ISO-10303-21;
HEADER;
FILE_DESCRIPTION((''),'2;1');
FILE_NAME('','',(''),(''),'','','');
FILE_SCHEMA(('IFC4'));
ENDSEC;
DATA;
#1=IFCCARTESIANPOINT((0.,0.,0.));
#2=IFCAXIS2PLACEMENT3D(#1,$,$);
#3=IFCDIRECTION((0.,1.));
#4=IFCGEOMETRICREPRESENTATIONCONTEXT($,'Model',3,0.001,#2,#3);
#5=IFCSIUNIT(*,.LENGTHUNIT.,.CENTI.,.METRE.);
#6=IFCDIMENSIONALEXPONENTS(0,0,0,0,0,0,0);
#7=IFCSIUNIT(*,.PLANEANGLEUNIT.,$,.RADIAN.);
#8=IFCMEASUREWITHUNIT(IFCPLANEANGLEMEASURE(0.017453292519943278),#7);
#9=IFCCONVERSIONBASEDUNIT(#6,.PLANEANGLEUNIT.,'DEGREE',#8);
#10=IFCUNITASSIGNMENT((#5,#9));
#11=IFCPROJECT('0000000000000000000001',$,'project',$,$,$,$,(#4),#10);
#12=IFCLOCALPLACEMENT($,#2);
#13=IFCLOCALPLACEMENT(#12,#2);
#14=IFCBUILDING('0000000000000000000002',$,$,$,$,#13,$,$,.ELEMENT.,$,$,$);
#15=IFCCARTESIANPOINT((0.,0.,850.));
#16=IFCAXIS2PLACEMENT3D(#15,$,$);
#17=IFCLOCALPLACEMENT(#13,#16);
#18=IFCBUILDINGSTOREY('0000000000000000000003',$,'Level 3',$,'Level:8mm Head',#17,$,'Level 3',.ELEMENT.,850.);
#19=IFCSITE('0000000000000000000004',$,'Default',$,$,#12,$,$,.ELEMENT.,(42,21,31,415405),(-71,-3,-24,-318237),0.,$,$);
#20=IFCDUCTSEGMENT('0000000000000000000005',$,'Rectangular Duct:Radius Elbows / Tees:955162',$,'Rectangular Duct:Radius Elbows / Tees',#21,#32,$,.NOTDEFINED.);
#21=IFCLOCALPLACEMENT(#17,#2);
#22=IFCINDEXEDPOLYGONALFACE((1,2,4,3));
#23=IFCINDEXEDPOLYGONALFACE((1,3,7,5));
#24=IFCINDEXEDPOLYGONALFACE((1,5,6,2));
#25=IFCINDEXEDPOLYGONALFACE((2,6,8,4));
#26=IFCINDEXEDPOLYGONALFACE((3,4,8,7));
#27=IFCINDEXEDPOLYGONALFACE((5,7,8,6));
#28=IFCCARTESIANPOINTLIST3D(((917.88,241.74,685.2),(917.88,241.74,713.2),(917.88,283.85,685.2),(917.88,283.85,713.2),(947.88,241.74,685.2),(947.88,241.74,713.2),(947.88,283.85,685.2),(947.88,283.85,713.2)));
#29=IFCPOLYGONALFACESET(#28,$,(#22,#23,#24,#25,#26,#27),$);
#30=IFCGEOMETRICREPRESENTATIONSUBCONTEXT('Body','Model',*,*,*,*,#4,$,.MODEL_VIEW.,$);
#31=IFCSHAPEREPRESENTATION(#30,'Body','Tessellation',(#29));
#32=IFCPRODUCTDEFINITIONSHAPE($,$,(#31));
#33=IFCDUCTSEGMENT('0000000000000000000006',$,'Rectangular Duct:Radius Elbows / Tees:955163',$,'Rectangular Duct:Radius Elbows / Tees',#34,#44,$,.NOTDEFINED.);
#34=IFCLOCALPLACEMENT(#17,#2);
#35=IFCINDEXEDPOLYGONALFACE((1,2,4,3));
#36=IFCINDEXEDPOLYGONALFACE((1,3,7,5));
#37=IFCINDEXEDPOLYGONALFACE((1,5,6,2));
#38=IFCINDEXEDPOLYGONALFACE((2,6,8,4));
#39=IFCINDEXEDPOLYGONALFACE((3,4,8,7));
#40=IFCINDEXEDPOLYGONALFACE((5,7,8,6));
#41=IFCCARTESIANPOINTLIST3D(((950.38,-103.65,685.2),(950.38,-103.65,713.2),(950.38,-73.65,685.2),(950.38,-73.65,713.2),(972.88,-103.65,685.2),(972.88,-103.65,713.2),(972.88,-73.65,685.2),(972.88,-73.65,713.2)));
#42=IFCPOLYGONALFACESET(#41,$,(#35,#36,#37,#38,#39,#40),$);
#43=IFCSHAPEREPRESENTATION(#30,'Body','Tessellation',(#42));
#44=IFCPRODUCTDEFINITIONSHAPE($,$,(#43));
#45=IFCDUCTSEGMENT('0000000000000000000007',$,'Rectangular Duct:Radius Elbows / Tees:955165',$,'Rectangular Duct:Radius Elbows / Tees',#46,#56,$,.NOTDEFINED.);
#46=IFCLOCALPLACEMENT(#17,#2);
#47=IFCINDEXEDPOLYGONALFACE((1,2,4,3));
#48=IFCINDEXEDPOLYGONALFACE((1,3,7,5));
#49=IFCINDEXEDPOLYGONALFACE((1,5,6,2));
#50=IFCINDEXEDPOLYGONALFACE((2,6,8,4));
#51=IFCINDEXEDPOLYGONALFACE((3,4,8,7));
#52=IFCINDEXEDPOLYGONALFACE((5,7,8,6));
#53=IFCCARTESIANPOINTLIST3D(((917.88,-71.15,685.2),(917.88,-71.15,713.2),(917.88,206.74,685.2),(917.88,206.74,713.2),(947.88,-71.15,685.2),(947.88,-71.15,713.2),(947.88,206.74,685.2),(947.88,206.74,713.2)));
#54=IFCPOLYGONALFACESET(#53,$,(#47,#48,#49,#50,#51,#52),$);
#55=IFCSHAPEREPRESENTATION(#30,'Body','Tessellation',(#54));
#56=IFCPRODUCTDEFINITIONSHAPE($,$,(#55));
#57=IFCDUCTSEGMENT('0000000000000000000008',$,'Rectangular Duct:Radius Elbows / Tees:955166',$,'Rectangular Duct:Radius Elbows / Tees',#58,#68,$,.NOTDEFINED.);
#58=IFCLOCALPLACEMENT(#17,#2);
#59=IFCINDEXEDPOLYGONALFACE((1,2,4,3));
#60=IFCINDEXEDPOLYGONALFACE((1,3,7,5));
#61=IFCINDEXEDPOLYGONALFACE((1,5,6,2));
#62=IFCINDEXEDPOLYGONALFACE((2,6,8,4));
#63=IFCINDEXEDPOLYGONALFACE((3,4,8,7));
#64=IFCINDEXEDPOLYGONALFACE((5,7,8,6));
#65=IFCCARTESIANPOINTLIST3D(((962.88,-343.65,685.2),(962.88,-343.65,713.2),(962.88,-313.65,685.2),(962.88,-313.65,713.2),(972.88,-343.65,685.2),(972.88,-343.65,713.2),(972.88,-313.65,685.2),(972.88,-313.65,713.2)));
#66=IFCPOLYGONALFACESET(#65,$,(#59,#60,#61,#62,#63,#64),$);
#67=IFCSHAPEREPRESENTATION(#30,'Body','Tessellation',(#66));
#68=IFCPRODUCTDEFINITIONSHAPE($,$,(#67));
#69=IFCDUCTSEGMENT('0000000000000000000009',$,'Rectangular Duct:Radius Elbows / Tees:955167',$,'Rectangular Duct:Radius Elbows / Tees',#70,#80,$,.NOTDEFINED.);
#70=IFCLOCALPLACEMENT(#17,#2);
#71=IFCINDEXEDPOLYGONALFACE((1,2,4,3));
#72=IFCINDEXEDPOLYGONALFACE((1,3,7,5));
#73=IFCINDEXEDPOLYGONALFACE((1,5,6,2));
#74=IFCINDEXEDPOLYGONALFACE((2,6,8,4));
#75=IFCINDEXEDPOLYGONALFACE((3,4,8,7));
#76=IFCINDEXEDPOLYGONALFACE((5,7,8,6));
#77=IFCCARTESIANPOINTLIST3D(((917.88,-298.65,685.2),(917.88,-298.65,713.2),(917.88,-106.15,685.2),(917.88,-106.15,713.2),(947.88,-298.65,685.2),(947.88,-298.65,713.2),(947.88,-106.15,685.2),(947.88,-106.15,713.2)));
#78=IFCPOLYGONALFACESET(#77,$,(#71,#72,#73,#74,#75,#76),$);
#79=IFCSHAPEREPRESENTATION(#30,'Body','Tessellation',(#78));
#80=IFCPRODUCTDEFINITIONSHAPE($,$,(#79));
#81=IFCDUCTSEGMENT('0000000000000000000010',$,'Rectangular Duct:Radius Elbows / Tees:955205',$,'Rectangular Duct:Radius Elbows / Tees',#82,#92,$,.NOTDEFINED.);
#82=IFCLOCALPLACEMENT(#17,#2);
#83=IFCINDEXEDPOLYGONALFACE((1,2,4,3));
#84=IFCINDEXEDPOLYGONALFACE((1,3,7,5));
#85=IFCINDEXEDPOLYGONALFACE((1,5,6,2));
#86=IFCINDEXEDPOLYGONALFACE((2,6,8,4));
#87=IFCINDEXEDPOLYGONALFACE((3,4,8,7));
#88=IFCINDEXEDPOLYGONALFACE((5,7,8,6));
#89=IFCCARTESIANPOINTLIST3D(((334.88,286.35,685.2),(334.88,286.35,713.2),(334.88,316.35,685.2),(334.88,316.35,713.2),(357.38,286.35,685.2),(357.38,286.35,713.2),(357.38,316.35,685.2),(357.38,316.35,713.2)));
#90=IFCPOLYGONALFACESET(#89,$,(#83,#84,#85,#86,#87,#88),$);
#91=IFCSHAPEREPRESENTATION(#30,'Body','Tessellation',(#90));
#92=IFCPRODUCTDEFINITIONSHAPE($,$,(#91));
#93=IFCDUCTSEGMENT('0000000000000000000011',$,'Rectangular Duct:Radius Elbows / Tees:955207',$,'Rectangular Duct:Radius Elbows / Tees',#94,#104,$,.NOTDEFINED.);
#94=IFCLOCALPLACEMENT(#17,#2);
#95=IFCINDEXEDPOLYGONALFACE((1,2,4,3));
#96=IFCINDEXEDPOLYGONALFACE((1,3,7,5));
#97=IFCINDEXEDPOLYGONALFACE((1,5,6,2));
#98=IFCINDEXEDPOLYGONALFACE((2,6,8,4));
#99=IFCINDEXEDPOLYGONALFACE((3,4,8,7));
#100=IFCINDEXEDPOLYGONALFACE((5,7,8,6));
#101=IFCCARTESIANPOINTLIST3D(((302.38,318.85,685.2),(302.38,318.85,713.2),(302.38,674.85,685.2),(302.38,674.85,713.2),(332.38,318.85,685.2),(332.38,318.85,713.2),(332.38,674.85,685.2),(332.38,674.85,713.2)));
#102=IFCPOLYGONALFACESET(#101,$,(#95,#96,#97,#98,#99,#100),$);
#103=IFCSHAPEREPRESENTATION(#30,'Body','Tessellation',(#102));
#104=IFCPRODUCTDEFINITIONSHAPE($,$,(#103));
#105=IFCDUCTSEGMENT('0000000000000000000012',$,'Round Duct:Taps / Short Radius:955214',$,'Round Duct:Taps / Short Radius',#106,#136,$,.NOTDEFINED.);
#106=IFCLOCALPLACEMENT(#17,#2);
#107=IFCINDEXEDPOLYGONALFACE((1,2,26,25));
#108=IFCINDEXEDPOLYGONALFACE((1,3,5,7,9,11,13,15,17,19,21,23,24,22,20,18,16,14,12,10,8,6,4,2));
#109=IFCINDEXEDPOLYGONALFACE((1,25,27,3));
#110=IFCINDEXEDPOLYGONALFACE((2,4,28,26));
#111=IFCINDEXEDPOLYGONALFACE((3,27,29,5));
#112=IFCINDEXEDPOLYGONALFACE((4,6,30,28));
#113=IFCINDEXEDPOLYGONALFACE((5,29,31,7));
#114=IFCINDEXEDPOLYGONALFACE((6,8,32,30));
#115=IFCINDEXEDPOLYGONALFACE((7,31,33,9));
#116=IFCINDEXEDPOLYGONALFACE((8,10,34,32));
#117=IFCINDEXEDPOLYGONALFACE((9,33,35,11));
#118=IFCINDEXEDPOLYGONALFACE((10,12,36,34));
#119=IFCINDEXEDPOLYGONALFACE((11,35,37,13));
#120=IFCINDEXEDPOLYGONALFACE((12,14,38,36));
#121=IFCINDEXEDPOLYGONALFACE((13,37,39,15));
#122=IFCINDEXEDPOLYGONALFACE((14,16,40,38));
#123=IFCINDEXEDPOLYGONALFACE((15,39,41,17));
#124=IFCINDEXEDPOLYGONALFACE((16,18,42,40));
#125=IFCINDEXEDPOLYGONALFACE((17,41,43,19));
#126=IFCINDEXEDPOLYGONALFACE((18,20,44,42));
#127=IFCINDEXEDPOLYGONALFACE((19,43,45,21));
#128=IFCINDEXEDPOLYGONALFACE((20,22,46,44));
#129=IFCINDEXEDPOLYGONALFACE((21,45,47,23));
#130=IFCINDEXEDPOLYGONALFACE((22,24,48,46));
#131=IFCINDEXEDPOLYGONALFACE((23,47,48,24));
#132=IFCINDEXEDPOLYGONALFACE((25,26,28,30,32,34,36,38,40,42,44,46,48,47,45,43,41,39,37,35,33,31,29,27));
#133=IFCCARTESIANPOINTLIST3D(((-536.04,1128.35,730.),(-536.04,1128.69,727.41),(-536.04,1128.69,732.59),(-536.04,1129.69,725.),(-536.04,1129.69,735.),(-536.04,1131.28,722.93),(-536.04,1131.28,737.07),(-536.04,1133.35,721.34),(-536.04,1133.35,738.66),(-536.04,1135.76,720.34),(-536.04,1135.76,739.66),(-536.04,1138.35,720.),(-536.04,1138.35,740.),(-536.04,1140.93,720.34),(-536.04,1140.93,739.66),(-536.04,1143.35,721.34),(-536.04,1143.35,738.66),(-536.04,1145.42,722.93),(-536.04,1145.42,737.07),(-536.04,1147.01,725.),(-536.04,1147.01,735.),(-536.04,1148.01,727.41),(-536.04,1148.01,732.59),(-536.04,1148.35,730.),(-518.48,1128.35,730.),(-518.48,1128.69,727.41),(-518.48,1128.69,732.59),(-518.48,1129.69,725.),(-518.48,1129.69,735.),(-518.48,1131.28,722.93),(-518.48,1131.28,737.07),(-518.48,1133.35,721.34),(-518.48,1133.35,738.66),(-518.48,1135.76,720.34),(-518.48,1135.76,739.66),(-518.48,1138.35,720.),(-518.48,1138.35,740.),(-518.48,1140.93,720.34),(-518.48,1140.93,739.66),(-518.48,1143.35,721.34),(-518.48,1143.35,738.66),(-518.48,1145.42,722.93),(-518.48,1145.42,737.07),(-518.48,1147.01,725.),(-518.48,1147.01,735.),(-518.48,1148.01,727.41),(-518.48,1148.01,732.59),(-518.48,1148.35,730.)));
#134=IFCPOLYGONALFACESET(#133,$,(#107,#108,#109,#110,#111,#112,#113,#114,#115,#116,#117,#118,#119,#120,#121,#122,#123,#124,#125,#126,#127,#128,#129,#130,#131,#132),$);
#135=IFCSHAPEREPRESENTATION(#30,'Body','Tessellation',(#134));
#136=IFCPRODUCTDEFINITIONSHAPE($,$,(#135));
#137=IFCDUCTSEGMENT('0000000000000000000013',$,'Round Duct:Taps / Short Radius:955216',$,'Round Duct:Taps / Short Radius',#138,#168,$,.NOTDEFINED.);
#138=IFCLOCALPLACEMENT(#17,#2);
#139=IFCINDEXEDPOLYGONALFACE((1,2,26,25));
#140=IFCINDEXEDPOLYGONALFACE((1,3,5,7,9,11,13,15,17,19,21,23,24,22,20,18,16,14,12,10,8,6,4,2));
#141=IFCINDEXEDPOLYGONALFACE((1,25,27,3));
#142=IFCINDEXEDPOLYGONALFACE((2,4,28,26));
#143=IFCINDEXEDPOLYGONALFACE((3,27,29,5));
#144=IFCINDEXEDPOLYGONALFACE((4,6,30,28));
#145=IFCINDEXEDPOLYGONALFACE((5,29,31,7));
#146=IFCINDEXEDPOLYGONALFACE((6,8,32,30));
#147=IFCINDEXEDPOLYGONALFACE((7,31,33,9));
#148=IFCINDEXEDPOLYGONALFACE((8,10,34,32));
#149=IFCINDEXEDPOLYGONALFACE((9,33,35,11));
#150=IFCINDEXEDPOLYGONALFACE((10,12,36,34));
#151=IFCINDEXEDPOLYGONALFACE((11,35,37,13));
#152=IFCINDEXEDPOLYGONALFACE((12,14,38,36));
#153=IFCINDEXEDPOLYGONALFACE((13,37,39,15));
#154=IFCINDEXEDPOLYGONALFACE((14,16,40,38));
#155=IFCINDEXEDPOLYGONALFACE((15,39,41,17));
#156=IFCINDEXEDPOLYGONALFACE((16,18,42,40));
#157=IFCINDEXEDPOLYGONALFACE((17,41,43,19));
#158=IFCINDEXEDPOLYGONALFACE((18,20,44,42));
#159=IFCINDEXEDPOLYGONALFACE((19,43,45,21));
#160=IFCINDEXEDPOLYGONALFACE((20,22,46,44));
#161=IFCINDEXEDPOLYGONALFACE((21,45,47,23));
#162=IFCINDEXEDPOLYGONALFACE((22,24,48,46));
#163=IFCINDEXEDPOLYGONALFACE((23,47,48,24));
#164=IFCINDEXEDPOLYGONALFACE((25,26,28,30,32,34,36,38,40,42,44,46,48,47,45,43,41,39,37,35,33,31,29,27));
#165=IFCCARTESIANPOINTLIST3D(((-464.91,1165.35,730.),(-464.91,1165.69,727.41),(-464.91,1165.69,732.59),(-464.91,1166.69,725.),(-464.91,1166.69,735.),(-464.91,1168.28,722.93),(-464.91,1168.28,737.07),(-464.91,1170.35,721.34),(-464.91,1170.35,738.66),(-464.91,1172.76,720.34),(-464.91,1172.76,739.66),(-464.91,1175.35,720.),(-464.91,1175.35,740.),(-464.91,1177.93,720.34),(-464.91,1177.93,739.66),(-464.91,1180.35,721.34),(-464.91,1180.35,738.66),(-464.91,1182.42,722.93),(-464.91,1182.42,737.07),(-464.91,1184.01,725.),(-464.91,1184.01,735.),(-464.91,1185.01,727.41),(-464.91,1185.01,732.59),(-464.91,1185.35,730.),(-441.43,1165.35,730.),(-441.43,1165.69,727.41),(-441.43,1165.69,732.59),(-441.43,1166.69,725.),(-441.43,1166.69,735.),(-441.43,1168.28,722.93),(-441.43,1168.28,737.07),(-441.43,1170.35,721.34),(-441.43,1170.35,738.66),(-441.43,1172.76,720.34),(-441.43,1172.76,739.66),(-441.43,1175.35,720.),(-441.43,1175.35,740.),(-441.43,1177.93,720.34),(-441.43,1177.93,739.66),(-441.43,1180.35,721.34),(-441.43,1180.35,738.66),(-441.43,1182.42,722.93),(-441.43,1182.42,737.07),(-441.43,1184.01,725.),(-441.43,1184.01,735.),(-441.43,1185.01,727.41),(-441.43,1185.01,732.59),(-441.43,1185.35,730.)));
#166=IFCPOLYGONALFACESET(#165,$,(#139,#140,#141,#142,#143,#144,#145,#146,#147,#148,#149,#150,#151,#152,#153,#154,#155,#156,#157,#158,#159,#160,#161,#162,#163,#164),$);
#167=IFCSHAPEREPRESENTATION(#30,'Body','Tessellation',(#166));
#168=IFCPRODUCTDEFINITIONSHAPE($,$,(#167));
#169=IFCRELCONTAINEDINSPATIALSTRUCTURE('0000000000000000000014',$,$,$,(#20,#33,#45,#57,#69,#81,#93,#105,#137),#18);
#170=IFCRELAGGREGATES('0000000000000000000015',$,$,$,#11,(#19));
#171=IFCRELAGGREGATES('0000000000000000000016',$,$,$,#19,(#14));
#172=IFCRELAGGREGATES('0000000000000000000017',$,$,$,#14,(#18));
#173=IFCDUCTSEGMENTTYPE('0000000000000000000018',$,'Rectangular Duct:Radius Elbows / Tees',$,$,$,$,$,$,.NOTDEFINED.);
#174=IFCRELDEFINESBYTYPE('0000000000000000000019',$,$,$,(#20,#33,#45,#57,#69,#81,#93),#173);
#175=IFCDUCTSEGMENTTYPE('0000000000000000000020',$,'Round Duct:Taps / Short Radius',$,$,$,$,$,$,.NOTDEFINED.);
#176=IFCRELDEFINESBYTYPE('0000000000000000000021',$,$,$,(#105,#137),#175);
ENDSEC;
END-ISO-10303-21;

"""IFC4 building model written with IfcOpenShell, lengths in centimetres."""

from ifc_helpers import new_model, entity, si_unit, converted_unit, direction, frame, origin, place, context, subcontext, project, spatial, arc, indexed_curve, outline, extrude, type_object, element, save


model = new_model("IFC4")

# Units and contexts
model_context = context("Model", 3, precision=0.001, world=origin(), true_north=direction((0.0, 1.0)))
body_context = subcontext(model_context, "Body", "Model", "MODEL_VIEW")
ifc_project = project(units=[si_unit("LENGTHUNIT", "METRE", prefix="CENTI"), converted_unit("PLANEANGLEUNIT", "DEGREE", entity("IfcPlaneAngleMeasure", 0.017453292519943278), si_unit("PLANEANGLEUNIT", "RADIAN"), dimensions=[0, 0, 0, 0, 0, 0, 0])], contexts=[model_context])

# Site, building, storey
site_placement = place(None, origin())
site = spatial("IfcSite", under=ifc_project, at=site_placement, Name="Default", CompositionType="ELEMENT", RefLatitude=(42, 21, 31, 415405), RefLongitude=(-71, -3, -24, -318237), RefElevation=0.0)
building_placement = place(site_placement, origin())
building = spatial("IfcBuilding", under=site, at=building_placement, CompositionType="ELEMENT")
storey_placement = place(building_placement, frame((0.0, 0.0, 850.0)))
storey = spatial("IfcBuildingStorey", under=building, at=storey_placement, Name="Level 3", ObjectType="Level:8mm Head", LongName="Level 3", CompositionType="ELEMENT", Elevation=850.0)

# Duct segments
duct_segment_type_1 = type_object("IfcDuctSegmentType", Name="Rectangular Duct:Radius Elbows / Tees", PredefinedType="NOTDEFINED")
duct_segment_1_placement = place(storey_placement, origin())
element("IfcDuctSegment", 1, at=duct_segment_1_placement, inside=storey, type_object=duct_segment_type_1, Name="Rectangular Duct:Radius Elbows / Tees:955162", ObjectType="Rectangular Duct:Radius Elbows / Tees", PredefinedType="NOTDEFINED", context=body_context, shape_type="SweptSolid", body=[
    extrude(outline(indexed_curve([(-21.05, -15.0), (21.05, -15.0), (21.05, 15.0), (-21.05, 15.0), (-21.05, -15.0)], self_intersect=False)), frame((932.88, 262.79, 685.2), z_axis=(0.0, 0.0, 1.0), x_axis=(0.0, 1.0, 0.0)), (0.0, 0.0, 1.0), 28.0),
])
duct_segment_2_placement = place(storey_placement, origin())
element("IfcDuctSegment", 2, at=duct_segment_2_placement, inside=storey, type_object=duct_segment_type_1, Name="Rectangular Duct:Radius Elbows / Tees:955163", ObjectType="Rectangular Duct:Radius Elbows / Tees", PredefinedType="NOTDEFINED", context=body_context, shape_type="SweptSolid", body=[
    extrude(outline(indexed_curve([(-11.25, -15.0), (11.25, -15.0), (11.25, 15.0), (-11.25, 15.0), (-11.25, -15.0)], self_intersect=False)), frame((961.63, -88.65, 685.2)), (0.0, 0.0, 1.0), 28.0),
])
duct_segment_3_placement = place(storey_placement, origin())
element("IfcDuctSegment", 3, at=duct_segment_3_placement, inside=storey, type_object=duct_segment_type_1, Name="Rectangular Duct:Radius Elbows / Tees:955165", ObjectType="Rectangular Duct:Radius Elbows / Tees", PredefinedType="NOTDEFINED", context=body_context, shape_type="SweptSolid", body=[
    extrude(outline(indexed_curve([(-138.95, -15.0), (138.95, -15.0), (138.95, 15.0), (-138.95, 15.0), (-138.95, -15.0)], self_intersect=False)), frame((932.88, 67.79, 685.2), z_axis=(0.0, 0.0, 1.0), x_axis=(0.0, -1.0, 0.0)), (0.0, 0.0, 1.0), 28.0),
])
duct_segment_4_placement = place(storey_placement, origin())
element("IfcDuctSegment", 4, at=duct_segment_4_placement, inside=storey, type_object=duct_segment_type_1, Name="Rectangular Duct:Radius Elbows / Tees:955166", ObjectType="Rectangular Duct:Radius Elbows / Tees", PredefinedType="NOTDEFINED", context=body_context, shape_type="SweptSolid", body=[
    extrude(outline(indexed_curve([(-5.0, -15.0), (5.0, -15.0), (5.0, 15.0), (-5.0, 15.0), (-5.0, -15.0)], self_intersect=False)), frame((967.88, -328.65, 685.2)), (0.0, 0.0, 1.0), 28.0),
])
duct_segment_5_placement = place(storey_placement, origin())
element("IfcDuctSegment", 5, at=duct_segment_5_placement, inside=storey, type_object=duct_segment_type_1, Name="Rectangular Duct:Radius Elbows / Tees:955167", ObjectType="Rectangular Duct:Radius Elbows / Tees", PredefinedType="NOTDEFINED", context=body_context, shape_type="SweptSolid", body=[
    extrude(outline(indexed_curve([(-96.25, -15.0), (96.25, -15.0), (96.25, 15.0), (-96.25, 15.0), (-96.25, -15.0)], self_intersect=False)), frame((932.88, -202.4, 685.2), z_axis=(0.0, 0.0, 1.0), x_axis=(0.0, -1.0, 0.0)), (0.0, 0.0, 1.0), 28.0),
])
duct_segment_6_placement = place(storey_placement, origin())
element("IfcDuctSegment", 6, at=duct_segment_6_placement, inside=storey, type_object=duct_segment_type_1, Name="Rectangular Duct:Radius Elbows / Tees:955205", ObjectType="Rectangular Duct:Radius Elbows / Tees", PredefinedType="NOTDEFINED", context=body_context, shape_type="SweptSolid", body=[
    extrude(outline(indexed_curve([(-11.25, -15.0), (11.25, -15.0), (11.25, 15.0), (-11.25, 15.0), (-11.25, -15.0)], self_intersect=False)), frame((346.13, 301.35, 685.2)), (0.0, 0.0, 1.0), 28.0),
])
duct_segment_7_placement = place(storey_placement, origin())
element("IfcDuctSegment", 7, at=duct_segment_7_placement, inside=storey, type_object=duct_segment_type_1, Name="Rectangular Duct:Radius Elbows / Tees:955207", ObjectType="Rectangular Duct:Radius Elbows / Tees", PredefinedType="NOTDEFINED", context=body_context, shape_type="SweptSolid", body=[
    extrude(outline(indexed_curve([(-178.0, -15.0), (178.0, -15.0), (178.0, 15.0), (-178.0, 15.0), (-178.0, -15.0)], self_intersect=False)), frame((317.38, 496.85, 685.2), z_axis=(0.0, 0.0, 1.0), x_axis=(0.0, -1.0, 0.0)), (0.0, 0.0, 1.0), 28.0),
])
duct_segment_type_2 = type_object("IfcDuctSegmentType", Name="Round Duct:Taps / Short Radius", PredefinedType="NOTDEFINED")
duct_segment_8_placement = place(storey_placement, origin())
element("IfcDuctSegment", 8, at=duct_segment_8_placement, inside=storey, type_object=duct_segment_type_2, Name="Round Duct:Taps / Short Radius:955214", ObjectType="Round Duct:Taps / Short Radius", PredefinedType="NOTDEFINED", context=body_context, shape_type="SweptSolid", body=[
    extrude(outline(indexed_curve([(10.0, 0.0), (7.07, 7.07), (0.0, 10.0), (-7.07, 7.07), (-10.0, 0.0), (-7.07, -7.07), (0.0, -10.0), (7.07, -7.07)], segments=[arc(1, 2, 3), arc(3, 4, 5), arc(5, 6, 7), arc(7, 8, 1)], self_intersect=False)), frame((-536.04, 1138.35, 730.0), z_axis=(1.0, 0.0, 0.0), x_axis=(0.0, 1.0, 0.0)), (0.0, 0.0, 1.0), 17.56),
])
duct_segment_9_placement = place(storey_placement, origin())
element("IfcDuctSegment", 9, at=duct_segment_9_placement, inside=storey, type_object=duct_segment_type_2, Name="Round Duct:Taps / Short Radius:955216", ObjectType="Round Duct:Taps / Short Radius", PredefinedType="NOTDEFINED", context=body_context, shape_type="SweptSolid", body=[
    extrude(outline(indexed_curve([(10.0, 0.0), (7.07, 7.07), (0.0, 10.0), (-7.07, 7.07), (-10.0, 0.0), (-7.07, -7.07), (0.0, -10.0), (7.07, -7.07)], segments=[arc(1, 2, 3), arc(3, 4, 5), arc(5, 6, 7), arc(7, 8, 1)], self_intersect=False)), frame((-464.91, 1175.35, 730.0), z_axis=(1.0, 0.0, 0.0), x_axis=(0.0, -1.0, 0.0)), (0.0, 0.0, 1.0), 23.48),
])

save(model, "model.ifc")
